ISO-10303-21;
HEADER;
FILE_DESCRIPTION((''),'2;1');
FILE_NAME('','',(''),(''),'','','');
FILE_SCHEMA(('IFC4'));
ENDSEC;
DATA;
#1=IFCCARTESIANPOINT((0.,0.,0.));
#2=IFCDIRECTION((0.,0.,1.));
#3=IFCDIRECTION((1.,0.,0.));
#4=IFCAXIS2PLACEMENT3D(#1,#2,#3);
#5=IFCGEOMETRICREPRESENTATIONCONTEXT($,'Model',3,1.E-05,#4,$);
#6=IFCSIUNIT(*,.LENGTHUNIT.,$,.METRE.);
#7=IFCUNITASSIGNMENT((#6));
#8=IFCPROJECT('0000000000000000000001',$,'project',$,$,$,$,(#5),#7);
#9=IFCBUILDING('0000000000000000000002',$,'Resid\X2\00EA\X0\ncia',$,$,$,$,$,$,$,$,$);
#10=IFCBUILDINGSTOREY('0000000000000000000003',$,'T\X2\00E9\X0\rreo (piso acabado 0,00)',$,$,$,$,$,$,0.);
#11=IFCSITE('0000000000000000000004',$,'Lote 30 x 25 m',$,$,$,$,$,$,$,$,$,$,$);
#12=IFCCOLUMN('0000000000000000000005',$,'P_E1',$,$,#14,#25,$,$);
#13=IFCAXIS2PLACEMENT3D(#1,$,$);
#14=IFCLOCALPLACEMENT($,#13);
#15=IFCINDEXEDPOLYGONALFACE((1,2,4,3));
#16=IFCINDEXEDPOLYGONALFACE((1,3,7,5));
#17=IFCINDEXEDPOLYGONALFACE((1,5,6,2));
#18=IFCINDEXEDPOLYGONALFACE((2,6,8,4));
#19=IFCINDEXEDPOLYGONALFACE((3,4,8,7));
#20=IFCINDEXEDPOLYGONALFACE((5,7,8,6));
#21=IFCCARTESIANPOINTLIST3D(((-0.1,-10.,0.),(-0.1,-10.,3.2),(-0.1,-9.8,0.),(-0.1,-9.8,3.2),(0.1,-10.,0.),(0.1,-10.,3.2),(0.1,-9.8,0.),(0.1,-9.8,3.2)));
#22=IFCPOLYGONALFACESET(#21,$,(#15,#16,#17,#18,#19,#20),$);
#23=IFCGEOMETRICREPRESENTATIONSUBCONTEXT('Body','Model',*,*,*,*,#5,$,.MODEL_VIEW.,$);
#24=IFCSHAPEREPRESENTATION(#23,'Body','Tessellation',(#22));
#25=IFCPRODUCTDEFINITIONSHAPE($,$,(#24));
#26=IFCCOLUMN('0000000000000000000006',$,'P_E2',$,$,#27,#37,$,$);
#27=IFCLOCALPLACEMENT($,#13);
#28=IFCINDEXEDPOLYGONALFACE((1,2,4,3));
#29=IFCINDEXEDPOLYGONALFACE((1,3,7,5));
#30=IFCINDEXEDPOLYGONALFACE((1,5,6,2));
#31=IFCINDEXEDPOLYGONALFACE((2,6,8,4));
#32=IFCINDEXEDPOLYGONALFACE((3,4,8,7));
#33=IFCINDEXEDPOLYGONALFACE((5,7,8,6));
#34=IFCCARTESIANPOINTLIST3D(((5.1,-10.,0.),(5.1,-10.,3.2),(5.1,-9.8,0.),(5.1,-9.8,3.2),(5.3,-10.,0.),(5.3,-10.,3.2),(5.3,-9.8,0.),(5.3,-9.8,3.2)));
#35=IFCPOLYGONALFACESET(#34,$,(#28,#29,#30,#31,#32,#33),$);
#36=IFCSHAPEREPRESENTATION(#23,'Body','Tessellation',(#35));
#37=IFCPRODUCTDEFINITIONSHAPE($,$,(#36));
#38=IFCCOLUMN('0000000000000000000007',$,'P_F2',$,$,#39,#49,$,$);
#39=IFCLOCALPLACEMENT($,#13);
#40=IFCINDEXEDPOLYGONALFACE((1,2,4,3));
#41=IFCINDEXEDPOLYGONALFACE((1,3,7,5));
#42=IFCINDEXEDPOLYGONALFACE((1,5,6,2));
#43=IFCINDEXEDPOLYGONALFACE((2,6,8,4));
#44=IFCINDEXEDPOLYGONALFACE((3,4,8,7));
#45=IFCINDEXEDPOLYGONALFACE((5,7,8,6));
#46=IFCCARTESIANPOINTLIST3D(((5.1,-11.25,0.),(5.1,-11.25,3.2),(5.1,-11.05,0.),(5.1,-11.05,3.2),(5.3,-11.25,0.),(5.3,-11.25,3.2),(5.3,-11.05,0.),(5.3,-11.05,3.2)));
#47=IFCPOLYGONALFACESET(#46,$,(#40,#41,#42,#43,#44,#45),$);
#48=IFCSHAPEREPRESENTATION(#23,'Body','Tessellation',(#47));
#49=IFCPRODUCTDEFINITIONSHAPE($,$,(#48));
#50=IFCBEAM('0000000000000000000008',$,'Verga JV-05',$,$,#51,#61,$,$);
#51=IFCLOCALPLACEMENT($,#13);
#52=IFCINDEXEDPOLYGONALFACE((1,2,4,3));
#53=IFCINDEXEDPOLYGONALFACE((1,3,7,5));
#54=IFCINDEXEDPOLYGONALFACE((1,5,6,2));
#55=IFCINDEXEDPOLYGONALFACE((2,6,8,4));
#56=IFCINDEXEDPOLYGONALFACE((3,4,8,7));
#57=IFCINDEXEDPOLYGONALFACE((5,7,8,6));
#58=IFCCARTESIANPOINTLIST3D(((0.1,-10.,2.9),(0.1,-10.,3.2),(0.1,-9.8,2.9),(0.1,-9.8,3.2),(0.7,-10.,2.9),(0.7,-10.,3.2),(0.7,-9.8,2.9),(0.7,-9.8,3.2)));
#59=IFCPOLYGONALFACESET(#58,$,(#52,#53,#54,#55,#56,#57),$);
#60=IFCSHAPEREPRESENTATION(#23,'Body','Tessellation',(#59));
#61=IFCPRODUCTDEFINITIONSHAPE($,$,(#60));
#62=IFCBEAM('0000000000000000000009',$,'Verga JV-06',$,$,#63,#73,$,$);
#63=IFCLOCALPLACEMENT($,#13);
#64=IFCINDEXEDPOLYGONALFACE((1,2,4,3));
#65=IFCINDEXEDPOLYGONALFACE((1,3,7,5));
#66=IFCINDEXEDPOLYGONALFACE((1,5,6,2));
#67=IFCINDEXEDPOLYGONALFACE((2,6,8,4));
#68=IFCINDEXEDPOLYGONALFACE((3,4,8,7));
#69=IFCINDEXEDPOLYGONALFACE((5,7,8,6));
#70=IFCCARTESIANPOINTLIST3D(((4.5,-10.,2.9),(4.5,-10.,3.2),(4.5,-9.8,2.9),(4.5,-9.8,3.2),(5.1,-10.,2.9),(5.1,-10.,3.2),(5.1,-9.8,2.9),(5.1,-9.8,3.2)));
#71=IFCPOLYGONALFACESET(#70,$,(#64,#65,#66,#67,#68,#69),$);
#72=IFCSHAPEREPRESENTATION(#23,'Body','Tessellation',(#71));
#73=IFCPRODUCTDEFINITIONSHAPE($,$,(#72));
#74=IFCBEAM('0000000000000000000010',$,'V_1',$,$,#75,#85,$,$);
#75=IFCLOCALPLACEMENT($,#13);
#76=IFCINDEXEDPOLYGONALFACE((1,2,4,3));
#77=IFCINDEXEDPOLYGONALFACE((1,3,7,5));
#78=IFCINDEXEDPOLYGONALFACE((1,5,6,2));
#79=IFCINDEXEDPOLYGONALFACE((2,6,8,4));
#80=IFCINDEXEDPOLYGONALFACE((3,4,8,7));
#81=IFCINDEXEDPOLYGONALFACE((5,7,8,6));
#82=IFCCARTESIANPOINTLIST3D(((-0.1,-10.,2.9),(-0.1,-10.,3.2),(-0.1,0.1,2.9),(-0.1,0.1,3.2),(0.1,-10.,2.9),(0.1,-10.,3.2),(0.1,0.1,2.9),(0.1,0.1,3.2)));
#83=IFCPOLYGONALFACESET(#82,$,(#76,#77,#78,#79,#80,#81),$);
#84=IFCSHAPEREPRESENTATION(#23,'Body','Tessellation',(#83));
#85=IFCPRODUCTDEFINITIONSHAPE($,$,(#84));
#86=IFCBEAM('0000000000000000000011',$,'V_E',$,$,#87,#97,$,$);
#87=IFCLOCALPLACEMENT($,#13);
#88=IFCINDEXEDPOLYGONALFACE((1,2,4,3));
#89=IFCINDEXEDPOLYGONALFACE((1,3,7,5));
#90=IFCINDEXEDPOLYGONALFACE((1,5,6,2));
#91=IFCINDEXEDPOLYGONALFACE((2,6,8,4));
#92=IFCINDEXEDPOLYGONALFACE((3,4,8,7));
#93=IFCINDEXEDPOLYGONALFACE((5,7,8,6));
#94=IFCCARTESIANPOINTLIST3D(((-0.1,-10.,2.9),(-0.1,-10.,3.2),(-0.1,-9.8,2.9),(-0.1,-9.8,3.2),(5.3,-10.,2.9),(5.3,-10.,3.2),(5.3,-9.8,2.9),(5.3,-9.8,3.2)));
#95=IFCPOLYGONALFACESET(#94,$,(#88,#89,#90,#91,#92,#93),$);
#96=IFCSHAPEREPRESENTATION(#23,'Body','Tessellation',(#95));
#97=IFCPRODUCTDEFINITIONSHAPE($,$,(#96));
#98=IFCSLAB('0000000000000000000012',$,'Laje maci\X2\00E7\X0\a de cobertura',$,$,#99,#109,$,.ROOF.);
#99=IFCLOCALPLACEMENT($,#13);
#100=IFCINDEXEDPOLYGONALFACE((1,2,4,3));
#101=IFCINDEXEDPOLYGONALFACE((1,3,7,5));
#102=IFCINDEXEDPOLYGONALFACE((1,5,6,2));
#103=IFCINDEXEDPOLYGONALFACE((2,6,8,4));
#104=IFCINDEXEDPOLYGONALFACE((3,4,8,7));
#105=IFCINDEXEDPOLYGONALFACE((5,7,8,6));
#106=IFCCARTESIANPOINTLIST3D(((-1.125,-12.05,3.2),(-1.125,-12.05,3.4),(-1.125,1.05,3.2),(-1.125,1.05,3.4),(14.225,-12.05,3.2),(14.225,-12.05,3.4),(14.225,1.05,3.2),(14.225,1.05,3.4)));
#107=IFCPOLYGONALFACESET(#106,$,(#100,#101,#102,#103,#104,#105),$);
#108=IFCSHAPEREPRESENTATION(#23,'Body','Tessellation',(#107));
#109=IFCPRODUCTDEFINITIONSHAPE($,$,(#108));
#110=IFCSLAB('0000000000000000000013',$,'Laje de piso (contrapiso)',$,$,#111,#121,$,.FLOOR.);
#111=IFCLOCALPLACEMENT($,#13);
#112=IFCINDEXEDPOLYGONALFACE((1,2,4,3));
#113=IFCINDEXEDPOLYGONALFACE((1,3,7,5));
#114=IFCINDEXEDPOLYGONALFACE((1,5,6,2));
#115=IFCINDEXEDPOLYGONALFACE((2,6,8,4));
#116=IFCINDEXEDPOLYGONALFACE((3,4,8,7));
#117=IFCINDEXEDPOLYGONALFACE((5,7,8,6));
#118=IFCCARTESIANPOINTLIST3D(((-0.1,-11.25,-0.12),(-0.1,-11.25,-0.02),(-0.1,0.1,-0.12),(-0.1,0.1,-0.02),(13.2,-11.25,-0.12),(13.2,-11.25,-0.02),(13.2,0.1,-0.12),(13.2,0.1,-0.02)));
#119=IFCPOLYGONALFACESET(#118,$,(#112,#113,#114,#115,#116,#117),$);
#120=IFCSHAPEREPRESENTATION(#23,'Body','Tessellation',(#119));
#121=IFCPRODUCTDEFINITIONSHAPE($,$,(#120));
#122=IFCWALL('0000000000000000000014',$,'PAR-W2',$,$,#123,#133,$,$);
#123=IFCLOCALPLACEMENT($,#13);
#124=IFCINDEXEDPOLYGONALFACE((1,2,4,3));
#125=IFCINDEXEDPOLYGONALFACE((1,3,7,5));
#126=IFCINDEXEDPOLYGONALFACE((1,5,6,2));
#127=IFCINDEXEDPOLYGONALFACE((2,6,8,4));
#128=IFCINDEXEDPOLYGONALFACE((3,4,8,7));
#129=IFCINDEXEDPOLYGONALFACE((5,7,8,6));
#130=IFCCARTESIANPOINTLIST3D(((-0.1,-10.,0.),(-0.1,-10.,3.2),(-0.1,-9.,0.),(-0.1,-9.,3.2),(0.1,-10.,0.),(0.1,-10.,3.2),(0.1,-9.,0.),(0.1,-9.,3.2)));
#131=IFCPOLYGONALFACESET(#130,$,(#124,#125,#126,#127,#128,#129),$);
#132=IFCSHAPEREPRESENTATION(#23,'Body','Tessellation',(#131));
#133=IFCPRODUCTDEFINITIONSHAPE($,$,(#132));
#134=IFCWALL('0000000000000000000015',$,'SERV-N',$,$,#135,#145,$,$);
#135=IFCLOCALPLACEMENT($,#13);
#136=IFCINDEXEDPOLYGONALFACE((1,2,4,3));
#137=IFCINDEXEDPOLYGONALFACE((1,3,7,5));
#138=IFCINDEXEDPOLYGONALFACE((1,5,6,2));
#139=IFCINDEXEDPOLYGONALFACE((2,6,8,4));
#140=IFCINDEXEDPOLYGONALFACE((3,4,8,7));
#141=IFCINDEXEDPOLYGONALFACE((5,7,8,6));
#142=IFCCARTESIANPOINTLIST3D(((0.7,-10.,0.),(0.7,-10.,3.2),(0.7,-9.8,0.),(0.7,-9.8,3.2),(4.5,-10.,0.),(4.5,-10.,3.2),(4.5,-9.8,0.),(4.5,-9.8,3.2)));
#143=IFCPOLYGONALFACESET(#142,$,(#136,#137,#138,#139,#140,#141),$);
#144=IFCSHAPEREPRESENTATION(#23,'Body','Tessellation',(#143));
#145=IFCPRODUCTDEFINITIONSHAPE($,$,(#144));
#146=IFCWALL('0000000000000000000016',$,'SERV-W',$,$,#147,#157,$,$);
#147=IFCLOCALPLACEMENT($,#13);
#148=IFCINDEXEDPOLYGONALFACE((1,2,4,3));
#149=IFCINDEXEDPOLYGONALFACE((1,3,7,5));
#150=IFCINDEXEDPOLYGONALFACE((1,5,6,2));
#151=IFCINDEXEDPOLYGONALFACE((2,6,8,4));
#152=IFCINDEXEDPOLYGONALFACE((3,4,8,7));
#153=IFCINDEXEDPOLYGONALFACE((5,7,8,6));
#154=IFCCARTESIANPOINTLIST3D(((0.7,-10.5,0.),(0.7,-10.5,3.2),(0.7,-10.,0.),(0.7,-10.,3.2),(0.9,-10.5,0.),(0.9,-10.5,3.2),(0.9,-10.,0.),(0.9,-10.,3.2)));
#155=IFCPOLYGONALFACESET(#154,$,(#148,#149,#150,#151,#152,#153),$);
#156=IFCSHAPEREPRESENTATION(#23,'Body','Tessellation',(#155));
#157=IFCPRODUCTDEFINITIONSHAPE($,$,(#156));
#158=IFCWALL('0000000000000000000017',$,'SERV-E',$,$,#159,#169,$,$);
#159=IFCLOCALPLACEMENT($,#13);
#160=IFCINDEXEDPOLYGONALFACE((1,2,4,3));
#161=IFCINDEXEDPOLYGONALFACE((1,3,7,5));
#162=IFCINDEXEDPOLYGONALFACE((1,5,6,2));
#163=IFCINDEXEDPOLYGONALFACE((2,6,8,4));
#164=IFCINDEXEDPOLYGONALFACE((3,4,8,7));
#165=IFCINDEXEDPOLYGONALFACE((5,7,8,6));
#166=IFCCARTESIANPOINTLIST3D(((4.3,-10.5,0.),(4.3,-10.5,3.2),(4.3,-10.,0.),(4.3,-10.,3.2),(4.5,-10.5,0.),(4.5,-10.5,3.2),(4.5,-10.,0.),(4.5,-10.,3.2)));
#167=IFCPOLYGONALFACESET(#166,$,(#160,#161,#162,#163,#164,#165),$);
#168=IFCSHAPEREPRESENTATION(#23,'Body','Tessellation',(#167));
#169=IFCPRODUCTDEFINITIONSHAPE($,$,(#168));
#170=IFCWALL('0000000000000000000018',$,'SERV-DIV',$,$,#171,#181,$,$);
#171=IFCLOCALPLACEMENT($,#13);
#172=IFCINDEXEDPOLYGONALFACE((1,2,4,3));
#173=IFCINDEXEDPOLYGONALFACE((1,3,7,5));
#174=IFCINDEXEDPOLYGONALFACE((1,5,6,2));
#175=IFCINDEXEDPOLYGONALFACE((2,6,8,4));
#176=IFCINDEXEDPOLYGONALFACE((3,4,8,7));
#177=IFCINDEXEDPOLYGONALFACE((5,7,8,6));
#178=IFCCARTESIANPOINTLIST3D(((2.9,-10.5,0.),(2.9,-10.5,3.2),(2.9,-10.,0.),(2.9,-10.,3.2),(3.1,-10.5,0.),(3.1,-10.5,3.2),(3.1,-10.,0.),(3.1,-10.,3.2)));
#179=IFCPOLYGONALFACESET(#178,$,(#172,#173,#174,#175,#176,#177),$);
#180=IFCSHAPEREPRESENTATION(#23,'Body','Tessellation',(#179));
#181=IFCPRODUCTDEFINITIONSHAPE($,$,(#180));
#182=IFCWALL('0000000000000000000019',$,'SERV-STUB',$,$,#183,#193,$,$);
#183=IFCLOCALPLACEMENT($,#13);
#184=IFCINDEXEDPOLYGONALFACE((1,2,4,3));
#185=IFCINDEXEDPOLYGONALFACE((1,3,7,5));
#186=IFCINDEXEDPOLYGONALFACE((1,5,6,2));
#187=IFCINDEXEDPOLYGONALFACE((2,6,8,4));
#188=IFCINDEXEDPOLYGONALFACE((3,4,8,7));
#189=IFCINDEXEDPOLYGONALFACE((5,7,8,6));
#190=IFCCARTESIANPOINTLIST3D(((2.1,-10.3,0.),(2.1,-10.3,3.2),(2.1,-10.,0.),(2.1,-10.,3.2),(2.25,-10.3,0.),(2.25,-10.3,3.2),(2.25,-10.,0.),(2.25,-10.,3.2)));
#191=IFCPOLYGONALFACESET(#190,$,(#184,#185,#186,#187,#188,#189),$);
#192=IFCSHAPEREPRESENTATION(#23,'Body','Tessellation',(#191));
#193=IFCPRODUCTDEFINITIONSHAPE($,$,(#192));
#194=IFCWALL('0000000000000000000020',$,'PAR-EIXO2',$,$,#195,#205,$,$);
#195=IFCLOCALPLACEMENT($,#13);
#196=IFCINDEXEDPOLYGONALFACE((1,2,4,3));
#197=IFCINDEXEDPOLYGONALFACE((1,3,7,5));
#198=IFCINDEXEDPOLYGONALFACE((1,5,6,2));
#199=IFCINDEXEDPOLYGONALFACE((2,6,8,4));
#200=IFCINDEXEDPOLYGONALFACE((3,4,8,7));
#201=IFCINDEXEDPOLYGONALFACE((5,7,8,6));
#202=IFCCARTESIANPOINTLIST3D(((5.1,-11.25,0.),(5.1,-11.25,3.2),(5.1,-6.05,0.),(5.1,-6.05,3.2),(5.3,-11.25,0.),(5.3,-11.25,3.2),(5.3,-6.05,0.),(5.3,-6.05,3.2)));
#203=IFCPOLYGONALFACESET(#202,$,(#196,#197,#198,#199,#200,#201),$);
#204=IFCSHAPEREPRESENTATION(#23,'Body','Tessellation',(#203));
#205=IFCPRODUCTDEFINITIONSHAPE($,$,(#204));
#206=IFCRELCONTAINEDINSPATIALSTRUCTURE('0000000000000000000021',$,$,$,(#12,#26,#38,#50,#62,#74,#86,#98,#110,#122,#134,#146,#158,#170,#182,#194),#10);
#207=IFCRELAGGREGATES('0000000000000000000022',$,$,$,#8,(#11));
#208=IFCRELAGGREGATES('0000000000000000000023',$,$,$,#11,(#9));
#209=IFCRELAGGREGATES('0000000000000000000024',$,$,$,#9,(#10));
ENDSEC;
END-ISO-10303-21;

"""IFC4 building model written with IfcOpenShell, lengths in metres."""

from ifc_helpers import new_model, si_unit, frame, origin_with_axes, place, context, subcontext, project, spatial, line, indexed_curve, outline, extrude, element, save


model = new_model("IFC4")

# Units and contexts
model_context = context("Model", 3, precision=1e-05, world=origin_with_axes())
body_context = subcontext(model_context, "Body", "Model", "MODEL_VIEW")
ifc_project = project(units=[si_unit("LENGTHUNIT", "METRE")], contexts=[model_context])

# Site, building, storey
site = spatial("IfcSite", under=ifc_project, Name="Lote 30 x 25 m")
building = spatial("IfcBuilding", under=site, Name="Residência")
storey = spatial("IfcBuildingStorey", under=building, Name="Térreo (piso acabado 0,00)", Elevation=0.0)

# Columns
column_placement = place(None, frame((-0.1, -10.0, 0.0), z_axis=(0.0, 0.0, 1.0), x_axis=(1.0, 0.0, 0.0)))
element("IfcColumn", 1, at=column_placement, inside=storey, Name="P_E1", context=body_context, shape_type="SweptSolid", body=[
    extrude(outline(indexed_curve([(0.0, 0.0), (0.2, 0.0), (0.2, 0.2), (0.0, 0.2)], segments=[line(1, 2, 3, 4, 1)])), origin_with_axes(), (0.0, 0.0, 1.0), 3.2),
])
for number, where, z_axis, x_axis, name in (
    (2, (5.1, -10.0, 0.0), (0.0, 0.0, 1.0), (1.0, 0.0, 0.0), "P_E2"),
    (3, (5.1, -11.25, 0.0), (0.0, 0.0, 1.0), (1.0, 0.0, 0.0), "P_F2"),
):
    element("IfcColumn", number, at=place(None, frame(where, z_axis=z_axis, x_axis=x_axis)), inside=storey, Name=name, context=body_context, shape_type="SweptSolid", body=[
        extrude(outline(indexed_curve([(0.0, 0.0), (0.2, 0.0), (0.2, 0.2), (0.0, 0.2)], segments=[line(1, 2, 3, 4, 1)])), origin_with_axes(), (0.0, 0.0, 1.0), 3.2),
    ])

# Beams
for number, where, z_axis, x_axis, name in (
    (4, (0.1, -10.0, 2.9), (0.0, 0.0, 1.0), (1.0, 0.0, 0.0), "Verga JV-05"),
    (5, (4.5, -10.0, 2.9), (0.0, 0.0, 1.0), (1.0, 0.0, 0.0), "Verga JV-06"),
):
    element("IfcBeam", number, at=place(None, frame(where, z_axis=z_axis, x_axis=x_axis)), inside=storey, Name=name, context=body_context, shape_type="SweptSolid", body=[
        extrude(outline(indexed_curve([(0.0, 0.0), (0.6, 0.0), (0.6, 0.2), (0.0, 0.2)], segments=[line(1, 2, 3, 4, 1)])), origin_with_axes(), (0.0, 0.0, 1.0), 0.3),
    ])
beam_1_placement = place(None, frame((-0.1, -10.0, 2.9), z_axis=(0.0, 0.0, 1.0), x_axis=(1.0, 0.0, 0.0)))
element("IfcBeam", 6, at=beam_1_placement, inside=storey, Name="V_1", context=body_context, shape_type="SweptSolid", body=[
    extrude(outline(indexed_curve([(0.0, 0.0), (0.2, 0.0), (0.2, 10.1), (0.0, 10.1)], segments=[line(1, 2, 3, 4, 1)])), origin_with_axes(), (0.0, 0.0, 1.0), 0.3),
])
beam_2_placement = place(None, frame((-0.1, -10.0, 2.9), z_axis=(0.0, 0.0, 1.0), x_axis=(1.0, 0.0, 0.0)))
element("IfcBeam", 7, at=beam_2_placement, inside=storey, Name="V_E", context=body_context, shape_type="SweptSolid", body=[
    extrude(outline(indexed_curve([(0.0, 0.0), (5.4, 0.0), (5.4, 0.2), (0.0, 0.2)], segments=[line(1, 2, 3, 4, 1)])), origin_with_axes(), (0.0, 0.0, 1.0), 0.3),
])

# Slabs
slab_1_placement = place(None, frame((-1.125, -12.05, 3.2), z_axis=(0.0, 0.0, 1.0), x_axis=(1.0, 0.0, 0.0)))
element("IfcSlab", 8, at=slab_1_placement, inside=storey, Name="Laje maciça de cobertura", PredefinedType="ROOF", context=body_context, shape_type="SweptSolid", body=[
    extrude(outline(indexed_curve([(0.0, 0.0), (15.35, 0.0), (15.35, 13.1), (0.0, 13.1)], segments=[line(1, 2, 3, 4, 1)])), origin_with_axes(), (0.0, 0.0, 1.0), 0.2),
])
slab_2_placement = place(None, frame((-0.1, -11.25, -0.12), z_axis=(0.0, 0.0, 1.0), x_axis=(1.0, 0.0, 0.0)))
element("IfcSlab", 9, at=slab_2_placement, inside=storey, Name="Laje de piso (contrapiso)", PredefinedType="FLOOR", context=body_context, shape_type="SweptSolid", body=[
    extrude(outline(indexed_curve([(0.0, 0.0), (13.3, 0.0), (13.3, 11.35), (0.0, 11.35)], segments=[line(1, 2, 3, 4, 1)])), origin_with_axes(), (0.0, 0.0, 1.0), 0.1),
])

# Walls
wall_1_placement = place(None, frame((-0.1, -10.0, 0.0), z_axis=(0.0, 0.0, 1.0), x_axis=(1.0, 0.0, 0.0)))
element("IfcWall", 10, at=wall_1_placement, inside=storey, Name="PAR-W2", context=body_context, shape_type="SweptSolid", body=[
    extrude(outline(indexed_curve([(0.0, 0.0), (0.2, 0.0), (0.2, 1.0), (0.0, 1.0)], segments=[line(1, 2, 3, 4, 1)])), origin_with_axes(), (0.0, 0.0, 1.0), 3.2),
])
wall_2_placement = place(None, frame((0.7, -10.0, 0.0), z_axis=(0.0, 0.0, 1.0), x_axis=(1.0, 0.0, 0.0)))
element("IfcWall", 11, at=wall_2_placement, inside=storey, Name="SERV-N", context=body_context, shape_type="SweptSolid", body=[
    extrude(outline(indexed_curve([(0.0, 0.0), (3.8, 0.0), (3.8, 0.2), (0.0, 0.2)], segments=[line(1, 2, 3, 4, 1)])), origin_with_axes(), (0.0, 0.0, 1.0), 3.2),
])
for number, where, z_axis, x_axis, name in (
    (12, (0.7, -10.5, 0.0), (0.0, 0.0, 1.0), (1.0, 0.0, 0.0), "SERV-W"),
    (13, (4.3, -10.5, 0.0), (0.0, 0.0, 1.0), (1.0, 0.0, 0.0), "SERV-E"),
    (14, (2.9, -10.5, 0.0), (0.0, 0.0, 1.0), (1.0, 0.0, 0.0), "SERV-DIV"),
):
    element("IfcWall", number, at=place(None, frame(where, z_axis=z_axis, x_axis=x_axis)), inside=storey, Name=name, context=body_context, shape_type="SweptSolid", body=[
        extrude(outline(indexed_curve([(0.0, 0.0), (0.2, 0.0), (0.2, 0.5), (0.0, 0.5)], segments=[line(1, 2, 3, 4, 1)])), origin_with_axes(), (0.0, 0.0, 1.0), 3.2),
    ])
wall_3_placement = place(None, frame((2.1, -10.3, 0.0), z_axis=(0.0, 0.0, 1.0), x_axis=(1.0, 0.0, 0.0)))
element("IfcWall", 15, at=wall_3_placement, inside=storey, Name="SERV-STUB", context=body_context, shape_type="SweptSolid", body=[
    extrude(outline(indexed_curve([(0.0, 0.0), (0.15, 0.0), (0.15, 0.3), (0.0, 0.3)], segments=[line(1, 2, 3, 4, 1)])), origin_with_axes(), (0.0, 0.0, 1.0), 3.2),
])
wall_4_placement = place(None, frame((5.1, -11.25, 0.0), z_axis=(0.0, 0.0, 1.0), x_axis=(1.0, 0.0, 0.0)))
element("IfcWall", 16, at=wall_4_placement, inside=storey, Name="PAR-EIXO2", context=body_context, shape_type="SweptSolid", body=[
    extrude(outline(indexed_curve([(0.0, 0.0), (0.2, 0.0), (0.2, 5.2), (0.0, 5.2)], segments=[line(1, 2, 3, 4, 1)])), origin_with_axes(), (0.0, 0.0, 1.0), 3.2),
])

save(model, "model.ifc")
